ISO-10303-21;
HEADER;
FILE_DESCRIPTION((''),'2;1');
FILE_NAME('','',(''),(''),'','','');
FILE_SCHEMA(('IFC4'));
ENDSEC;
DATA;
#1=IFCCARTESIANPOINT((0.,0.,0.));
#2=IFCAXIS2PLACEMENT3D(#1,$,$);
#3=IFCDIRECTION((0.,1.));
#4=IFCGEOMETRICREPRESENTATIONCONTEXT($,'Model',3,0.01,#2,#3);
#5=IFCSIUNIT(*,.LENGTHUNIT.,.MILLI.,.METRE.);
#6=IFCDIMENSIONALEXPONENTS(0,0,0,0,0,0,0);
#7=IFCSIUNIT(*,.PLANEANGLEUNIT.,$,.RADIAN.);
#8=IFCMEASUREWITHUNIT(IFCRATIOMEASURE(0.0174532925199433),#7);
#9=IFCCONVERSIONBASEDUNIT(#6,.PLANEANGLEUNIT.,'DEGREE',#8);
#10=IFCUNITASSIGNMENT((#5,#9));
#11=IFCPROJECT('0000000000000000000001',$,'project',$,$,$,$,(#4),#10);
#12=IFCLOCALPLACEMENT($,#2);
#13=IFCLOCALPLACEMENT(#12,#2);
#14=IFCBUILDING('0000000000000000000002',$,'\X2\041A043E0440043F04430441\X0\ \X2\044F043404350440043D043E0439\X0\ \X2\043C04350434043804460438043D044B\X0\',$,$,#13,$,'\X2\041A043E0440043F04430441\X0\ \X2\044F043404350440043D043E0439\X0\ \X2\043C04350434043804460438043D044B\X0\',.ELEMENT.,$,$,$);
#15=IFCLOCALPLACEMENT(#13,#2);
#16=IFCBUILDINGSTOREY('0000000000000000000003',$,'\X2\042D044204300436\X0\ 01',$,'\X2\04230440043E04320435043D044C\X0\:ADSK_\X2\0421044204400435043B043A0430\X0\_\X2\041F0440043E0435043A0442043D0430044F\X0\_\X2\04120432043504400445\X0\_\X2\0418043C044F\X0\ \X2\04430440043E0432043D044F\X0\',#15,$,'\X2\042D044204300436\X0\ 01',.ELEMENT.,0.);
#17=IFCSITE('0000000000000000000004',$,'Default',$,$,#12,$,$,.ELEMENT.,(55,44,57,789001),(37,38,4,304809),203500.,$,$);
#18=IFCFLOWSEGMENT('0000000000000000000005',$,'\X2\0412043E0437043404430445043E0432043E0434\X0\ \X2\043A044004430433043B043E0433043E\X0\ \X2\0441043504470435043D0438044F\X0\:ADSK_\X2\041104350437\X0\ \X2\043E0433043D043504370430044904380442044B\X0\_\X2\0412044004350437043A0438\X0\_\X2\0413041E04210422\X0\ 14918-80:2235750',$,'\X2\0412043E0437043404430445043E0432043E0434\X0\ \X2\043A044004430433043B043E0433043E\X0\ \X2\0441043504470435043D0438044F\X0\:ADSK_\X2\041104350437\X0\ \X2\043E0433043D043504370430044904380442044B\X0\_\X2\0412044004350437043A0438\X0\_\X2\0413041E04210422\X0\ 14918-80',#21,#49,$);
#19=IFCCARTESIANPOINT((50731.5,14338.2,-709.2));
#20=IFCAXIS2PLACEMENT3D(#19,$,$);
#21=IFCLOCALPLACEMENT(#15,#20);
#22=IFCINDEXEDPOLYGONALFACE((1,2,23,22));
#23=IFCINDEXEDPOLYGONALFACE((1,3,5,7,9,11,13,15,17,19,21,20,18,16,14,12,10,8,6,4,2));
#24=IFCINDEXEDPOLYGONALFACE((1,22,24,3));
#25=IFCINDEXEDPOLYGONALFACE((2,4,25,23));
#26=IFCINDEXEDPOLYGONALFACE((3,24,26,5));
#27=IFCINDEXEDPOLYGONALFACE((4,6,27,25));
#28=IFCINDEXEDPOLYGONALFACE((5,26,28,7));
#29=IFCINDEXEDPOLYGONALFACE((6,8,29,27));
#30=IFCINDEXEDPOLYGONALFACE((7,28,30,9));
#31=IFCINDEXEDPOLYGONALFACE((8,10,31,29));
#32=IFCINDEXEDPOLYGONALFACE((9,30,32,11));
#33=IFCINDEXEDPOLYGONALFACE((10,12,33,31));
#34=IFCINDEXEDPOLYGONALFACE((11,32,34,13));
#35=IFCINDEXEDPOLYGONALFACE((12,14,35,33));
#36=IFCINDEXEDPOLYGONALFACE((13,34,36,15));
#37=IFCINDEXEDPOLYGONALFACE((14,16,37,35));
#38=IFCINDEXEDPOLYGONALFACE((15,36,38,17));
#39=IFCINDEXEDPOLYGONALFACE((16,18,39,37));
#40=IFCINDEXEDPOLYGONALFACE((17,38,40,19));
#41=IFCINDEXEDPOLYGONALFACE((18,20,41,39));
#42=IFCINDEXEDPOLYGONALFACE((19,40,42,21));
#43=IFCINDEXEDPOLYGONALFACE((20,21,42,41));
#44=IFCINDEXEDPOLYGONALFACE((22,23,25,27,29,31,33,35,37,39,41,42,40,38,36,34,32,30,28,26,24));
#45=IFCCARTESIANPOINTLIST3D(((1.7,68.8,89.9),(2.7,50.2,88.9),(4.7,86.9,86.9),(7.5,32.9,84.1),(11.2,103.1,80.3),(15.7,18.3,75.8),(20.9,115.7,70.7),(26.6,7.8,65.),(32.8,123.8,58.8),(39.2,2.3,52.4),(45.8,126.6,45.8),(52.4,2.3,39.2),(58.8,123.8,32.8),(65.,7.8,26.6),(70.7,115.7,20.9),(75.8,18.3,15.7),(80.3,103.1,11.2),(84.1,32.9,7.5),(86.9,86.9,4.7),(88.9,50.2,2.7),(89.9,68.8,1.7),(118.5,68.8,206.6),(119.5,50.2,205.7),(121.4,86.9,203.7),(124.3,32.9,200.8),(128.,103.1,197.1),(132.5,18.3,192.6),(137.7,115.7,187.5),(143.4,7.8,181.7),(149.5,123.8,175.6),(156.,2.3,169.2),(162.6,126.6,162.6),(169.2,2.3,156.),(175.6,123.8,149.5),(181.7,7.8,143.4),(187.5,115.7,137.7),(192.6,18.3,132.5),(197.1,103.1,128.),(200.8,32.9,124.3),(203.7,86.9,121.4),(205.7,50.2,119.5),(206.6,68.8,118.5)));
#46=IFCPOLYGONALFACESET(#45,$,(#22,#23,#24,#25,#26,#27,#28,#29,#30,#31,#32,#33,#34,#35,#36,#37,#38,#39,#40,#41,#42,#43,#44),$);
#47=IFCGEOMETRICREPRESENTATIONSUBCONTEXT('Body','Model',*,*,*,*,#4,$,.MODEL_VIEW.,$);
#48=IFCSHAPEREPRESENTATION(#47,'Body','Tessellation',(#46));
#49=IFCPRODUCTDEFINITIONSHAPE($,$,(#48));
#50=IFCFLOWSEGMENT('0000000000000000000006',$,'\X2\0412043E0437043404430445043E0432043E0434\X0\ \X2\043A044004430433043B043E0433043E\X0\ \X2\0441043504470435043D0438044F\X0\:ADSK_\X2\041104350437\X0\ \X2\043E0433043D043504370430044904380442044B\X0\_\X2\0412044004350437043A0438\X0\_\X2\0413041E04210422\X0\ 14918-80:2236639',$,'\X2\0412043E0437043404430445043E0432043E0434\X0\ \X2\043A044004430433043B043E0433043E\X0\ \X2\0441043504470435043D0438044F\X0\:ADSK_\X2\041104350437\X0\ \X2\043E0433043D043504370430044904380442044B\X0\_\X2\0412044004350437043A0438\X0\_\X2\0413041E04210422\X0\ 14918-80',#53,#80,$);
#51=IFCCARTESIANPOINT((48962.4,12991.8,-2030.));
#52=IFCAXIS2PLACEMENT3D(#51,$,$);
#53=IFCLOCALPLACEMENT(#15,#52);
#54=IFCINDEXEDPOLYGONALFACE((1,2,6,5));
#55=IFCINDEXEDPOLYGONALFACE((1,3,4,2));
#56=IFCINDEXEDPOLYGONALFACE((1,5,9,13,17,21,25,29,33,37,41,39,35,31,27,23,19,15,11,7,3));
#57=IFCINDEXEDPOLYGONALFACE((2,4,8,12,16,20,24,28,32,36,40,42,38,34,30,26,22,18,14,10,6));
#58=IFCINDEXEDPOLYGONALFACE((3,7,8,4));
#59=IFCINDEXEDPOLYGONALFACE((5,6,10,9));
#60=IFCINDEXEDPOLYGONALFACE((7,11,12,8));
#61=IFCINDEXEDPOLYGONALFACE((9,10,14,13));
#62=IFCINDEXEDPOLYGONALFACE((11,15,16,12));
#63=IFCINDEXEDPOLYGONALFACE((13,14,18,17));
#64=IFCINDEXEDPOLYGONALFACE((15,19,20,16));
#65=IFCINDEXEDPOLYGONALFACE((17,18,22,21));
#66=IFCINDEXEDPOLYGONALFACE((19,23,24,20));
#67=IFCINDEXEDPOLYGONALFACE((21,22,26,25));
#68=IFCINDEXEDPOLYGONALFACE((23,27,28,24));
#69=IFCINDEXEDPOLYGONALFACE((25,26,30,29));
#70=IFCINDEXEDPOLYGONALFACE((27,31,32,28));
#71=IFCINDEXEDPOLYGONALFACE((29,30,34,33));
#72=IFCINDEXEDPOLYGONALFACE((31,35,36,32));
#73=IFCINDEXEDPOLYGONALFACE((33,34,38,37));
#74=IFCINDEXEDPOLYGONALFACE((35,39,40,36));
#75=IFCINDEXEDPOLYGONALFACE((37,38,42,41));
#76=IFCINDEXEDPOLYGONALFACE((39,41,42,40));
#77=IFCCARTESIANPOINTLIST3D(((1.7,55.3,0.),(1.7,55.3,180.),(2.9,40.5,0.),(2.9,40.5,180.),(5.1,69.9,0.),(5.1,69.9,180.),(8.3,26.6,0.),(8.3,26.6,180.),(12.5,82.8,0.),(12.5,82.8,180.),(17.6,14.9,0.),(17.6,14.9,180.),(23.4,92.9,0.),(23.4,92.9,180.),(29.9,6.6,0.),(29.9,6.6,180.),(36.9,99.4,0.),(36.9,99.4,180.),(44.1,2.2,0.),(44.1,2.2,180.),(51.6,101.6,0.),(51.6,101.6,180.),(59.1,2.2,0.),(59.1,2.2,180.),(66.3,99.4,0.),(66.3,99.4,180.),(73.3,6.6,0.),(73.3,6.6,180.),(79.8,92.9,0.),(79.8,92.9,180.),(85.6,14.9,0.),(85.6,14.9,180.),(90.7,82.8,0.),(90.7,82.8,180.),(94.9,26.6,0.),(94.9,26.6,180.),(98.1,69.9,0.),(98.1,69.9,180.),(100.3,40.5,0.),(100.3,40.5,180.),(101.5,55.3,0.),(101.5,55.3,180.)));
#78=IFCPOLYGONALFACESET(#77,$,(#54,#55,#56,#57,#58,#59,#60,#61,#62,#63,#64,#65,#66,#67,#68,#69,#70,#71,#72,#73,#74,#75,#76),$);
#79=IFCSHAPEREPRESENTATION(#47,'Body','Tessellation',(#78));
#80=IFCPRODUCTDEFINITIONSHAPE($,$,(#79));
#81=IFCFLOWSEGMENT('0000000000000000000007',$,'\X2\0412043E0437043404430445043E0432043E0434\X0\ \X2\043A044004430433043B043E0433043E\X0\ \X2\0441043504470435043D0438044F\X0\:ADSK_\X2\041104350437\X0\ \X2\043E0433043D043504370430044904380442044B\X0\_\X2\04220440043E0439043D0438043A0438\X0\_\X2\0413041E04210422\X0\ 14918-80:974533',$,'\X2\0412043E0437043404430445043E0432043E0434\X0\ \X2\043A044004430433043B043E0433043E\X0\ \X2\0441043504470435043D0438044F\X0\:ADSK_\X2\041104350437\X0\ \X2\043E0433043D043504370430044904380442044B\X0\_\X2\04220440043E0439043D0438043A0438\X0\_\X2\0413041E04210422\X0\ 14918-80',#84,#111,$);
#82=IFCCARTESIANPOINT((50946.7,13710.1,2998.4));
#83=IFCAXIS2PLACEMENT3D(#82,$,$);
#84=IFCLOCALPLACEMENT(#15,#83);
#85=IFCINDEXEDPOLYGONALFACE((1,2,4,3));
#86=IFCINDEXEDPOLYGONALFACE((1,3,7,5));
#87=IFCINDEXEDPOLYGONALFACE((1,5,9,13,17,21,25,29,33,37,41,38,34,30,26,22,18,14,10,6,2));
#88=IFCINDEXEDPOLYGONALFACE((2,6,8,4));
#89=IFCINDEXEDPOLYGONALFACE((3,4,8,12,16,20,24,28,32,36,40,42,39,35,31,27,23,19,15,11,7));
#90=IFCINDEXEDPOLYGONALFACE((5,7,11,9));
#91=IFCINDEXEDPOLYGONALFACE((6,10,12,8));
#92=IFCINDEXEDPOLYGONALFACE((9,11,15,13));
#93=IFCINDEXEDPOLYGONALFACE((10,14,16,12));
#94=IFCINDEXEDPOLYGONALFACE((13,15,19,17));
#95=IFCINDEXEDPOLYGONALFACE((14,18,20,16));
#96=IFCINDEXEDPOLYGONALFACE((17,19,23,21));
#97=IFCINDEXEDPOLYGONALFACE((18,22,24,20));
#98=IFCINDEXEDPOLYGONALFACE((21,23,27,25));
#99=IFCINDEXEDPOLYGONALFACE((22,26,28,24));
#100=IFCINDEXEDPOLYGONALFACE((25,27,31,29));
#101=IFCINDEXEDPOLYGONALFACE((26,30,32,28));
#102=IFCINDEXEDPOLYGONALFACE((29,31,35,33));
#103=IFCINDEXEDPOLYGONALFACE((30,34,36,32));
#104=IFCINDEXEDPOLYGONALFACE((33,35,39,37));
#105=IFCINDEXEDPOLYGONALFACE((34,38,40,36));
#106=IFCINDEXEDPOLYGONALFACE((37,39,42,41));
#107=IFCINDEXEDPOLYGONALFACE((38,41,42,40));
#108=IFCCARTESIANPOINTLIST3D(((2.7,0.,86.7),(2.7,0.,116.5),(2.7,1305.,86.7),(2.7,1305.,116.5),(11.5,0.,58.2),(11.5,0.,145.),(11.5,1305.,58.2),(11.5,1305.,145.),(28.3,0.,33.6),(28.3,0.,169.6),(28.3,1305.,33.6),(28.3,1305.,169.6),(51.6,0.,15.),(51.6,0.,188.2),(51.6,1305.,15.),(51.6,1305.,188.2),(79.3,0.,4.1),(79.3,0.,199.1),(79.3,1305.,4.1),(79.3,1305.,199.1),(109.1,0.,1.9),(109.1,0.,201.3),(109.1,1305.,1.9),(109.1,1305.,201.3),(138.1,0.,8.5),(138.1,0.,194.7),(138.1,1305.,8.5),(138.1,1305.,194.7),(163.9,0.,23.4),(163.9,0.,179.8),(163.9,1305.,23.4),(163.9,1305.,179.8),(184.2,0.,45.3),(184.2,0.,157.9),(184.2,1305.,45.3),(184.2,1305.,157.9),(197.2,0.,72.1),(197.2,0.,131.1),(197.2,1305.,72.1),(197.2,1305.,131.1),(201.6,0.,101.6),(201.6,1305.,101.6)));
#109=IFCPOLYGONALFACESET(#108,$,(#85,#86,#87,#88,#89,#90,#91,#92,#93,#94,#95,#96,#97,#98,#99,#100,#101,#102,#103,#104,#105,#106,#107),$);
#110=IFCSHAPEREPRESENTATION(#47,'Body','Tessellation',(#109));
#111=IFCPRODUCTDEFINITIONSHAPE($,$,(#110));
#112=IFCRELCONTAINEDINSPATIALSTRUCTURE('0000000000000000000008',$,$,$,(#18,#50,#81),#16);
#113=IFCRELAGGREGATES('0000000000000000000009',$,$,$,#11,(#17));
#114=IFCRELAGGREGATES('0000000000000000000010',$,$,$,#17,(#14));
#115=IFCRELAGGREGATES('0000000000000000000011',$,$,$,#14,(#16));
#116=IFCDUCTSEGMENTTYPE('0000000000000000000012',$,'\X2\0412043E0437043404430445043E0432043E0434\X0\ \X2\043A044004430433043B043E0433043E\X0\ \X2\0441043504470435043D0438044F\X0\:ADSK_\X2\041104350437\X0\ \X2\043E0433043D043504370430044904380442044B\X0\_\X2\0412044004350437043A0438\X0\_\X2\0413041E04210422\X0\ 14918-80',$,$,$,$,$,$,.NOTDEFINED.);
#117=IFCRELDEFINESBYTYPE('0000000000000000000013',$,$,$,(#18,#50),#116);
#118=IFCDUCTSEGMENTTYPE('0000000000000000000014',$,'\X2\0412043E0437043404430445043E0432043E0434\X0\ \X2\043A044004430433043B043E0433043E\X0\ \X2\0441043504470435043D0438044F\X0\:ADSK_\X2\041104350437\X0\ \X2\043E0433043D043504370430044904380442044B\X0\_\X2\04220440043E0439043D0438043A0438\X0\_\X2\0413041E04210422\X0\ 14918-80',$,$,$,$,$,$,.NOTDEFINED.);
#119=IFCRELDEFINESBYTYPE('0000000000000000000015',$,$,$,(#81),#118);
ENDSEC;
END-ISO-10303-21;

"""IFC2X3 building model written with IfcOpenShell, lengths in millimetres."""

from ifc_helpers import new_model, entity, si_unit, converted_unit, direction, frame, origin, origin_2d_with_axis, place, context, subcontext, project, spatial, circle, extrude, type_object, element, save


model = new_model("IFC2X3")

# Units and contexts
model_context = context("Model", 3, precision=0.01, world=origin(), true_north=direction((0.0, 1.0)))
body_context = subcontext(model_context, "Body", "Model", "MODEL_VIEW")
ifc_project = project(units=[si_unit("LENGTHUNIT", "METRE", prefix="MILLI"), converted_unit("PLANEANGLEUNIT", "DEGREE", entity("IfcRatioMeasure", 0.0174532925199433), si_unit("PLANEANGLEUNIT", "RADIAN"), dimensions=[0, 0, 0, 0, 0, 0, 0])], contexts=[model_context])

# Site, building, storey
site_placement = place(None, origin())
site = spatial("IfcSite", under=ifc_project, at=site_placement, Name="Default", CompositionType="ELEMENT", RefLatitude=(55, 44, 57, 789001), RefLongitude=(37, 38, 4, 304809), RefElevation=203500.0)
building_placement = place(site_placement, origin())
building = spatial("IfcBuilding", under=site, at=building_placement, Name="Корпус ядерной медицины", LongName="Корпус ядерной медицины", CompositionType="ELEMENT")
storey_placement = place(building_placement, origin())
storey = spatial("IfcBuildingStorey", under=building, at=storey_placement, Name="Этаж 01", ObjectType="Уровень:ADSK_Стрелка_Проектная_Вверх_Имя уровня", LongName="Этаж 01", CompositionType="ELEMENT", Elevation=0.0)

# Flow segments
duct_segment_type_1 = type_object("IfcDuctSegmentType", Name="Воздуховод круглого сечения:ADSK_Без огнезащиты_Врезки_ГОСТ 14918-80", PredefinedType="NOTDEFINED")
flow_segment_1_placement = place(storey_placement, frame((50731.5, 14338.2, -709.2)))
element("IfcFlowSegment", 1, at=flow_segment_1_placement, inside=storey, type_object=duct_segment_type_1, Name="Воздуховод круглого сечения:ADSK_Без огнезащиты_Врезки_ГОСТ 14918-80:2235750", ObjectType="Воздуховод круглого сечения:ADSK_Без огнезащиты_Врезки_ГОСТ 14918-80", context=body_context, shape_type="SweptSolid", body=[
    extrude(circle(Radius=62.5, at=origin_2d_with_axis()), frame((45.8, 64.1, 45.8), z_axis=(0.707107, 0.0, 0.707107), x_axis=(0.0, 1.0, 0.0)), (0.0, 0.0, 1.0), 165.1),
])
flow_segment_2_placement = place(storey_placement, frame((48962.4, 12991.8, -2030.0)))
element("IfcFlowSegment", 2, at=flow_segment_2_placement, inside=storey, type_object=duct_segment_type_1, Name="Воздуховод круглого сечения:ADSK_Без огнезащиты_Врезки_ГОСТ 14918-80:2236639", ObjectType="Воздуховод круглого сечения:ADSK_Без огнезащиты_Врезки_ГОСТ 14918-80", context=body_context, shape_type="SweptSolid", body=[
    extrude(circle(Radius=50.0, at=origin_2d_with_axis()), frame((51.6, 51.6, 0.0), z_axis=(0.0, 0.0, 1.0), x_axis=(0.0, 1.0, 0.0)), (0.0, 0.0, 1.0), 180.0),
])
duct_segment_type_2 = type_object("IfcDuctSegmentType", Name="Воздуховод круглого сечения:ADSK_Без огнезащиты_Тройники_ГОСТ 14918-80", PredefinedType="NOTDEFINED")
flow_segment_3_placement = place(storey_placement, frame((50946.7, 13710.1, 2998.4)))
element("IfcFlowSegment", 3, at=flow_segment_3_placement, inside=storey, type_object=duct_segment_type_2, Name="Воздуховод круглого сечения:ADSK_Без огнезащиты_Тройники_ГОСТ 14918-80:974533", ObjectType="Воздуховод круглого сечения:ADSK_Без огнезащиты_Тройники_ГОСТ 14918-80", context=body_context, shape_type="SweptSolid", body=[
    extrude(circle(Radius=100.0, at=origin_2d_with_axis()), frame((101.6, 0.0, 101.6), z_axis=(0.0, 1.0, 0.0), x_axis=(1.0, 0.0, 0.0)), (0.0, 0.0, 1.0), 1305.0),
])

save(model, "model.ifc")
